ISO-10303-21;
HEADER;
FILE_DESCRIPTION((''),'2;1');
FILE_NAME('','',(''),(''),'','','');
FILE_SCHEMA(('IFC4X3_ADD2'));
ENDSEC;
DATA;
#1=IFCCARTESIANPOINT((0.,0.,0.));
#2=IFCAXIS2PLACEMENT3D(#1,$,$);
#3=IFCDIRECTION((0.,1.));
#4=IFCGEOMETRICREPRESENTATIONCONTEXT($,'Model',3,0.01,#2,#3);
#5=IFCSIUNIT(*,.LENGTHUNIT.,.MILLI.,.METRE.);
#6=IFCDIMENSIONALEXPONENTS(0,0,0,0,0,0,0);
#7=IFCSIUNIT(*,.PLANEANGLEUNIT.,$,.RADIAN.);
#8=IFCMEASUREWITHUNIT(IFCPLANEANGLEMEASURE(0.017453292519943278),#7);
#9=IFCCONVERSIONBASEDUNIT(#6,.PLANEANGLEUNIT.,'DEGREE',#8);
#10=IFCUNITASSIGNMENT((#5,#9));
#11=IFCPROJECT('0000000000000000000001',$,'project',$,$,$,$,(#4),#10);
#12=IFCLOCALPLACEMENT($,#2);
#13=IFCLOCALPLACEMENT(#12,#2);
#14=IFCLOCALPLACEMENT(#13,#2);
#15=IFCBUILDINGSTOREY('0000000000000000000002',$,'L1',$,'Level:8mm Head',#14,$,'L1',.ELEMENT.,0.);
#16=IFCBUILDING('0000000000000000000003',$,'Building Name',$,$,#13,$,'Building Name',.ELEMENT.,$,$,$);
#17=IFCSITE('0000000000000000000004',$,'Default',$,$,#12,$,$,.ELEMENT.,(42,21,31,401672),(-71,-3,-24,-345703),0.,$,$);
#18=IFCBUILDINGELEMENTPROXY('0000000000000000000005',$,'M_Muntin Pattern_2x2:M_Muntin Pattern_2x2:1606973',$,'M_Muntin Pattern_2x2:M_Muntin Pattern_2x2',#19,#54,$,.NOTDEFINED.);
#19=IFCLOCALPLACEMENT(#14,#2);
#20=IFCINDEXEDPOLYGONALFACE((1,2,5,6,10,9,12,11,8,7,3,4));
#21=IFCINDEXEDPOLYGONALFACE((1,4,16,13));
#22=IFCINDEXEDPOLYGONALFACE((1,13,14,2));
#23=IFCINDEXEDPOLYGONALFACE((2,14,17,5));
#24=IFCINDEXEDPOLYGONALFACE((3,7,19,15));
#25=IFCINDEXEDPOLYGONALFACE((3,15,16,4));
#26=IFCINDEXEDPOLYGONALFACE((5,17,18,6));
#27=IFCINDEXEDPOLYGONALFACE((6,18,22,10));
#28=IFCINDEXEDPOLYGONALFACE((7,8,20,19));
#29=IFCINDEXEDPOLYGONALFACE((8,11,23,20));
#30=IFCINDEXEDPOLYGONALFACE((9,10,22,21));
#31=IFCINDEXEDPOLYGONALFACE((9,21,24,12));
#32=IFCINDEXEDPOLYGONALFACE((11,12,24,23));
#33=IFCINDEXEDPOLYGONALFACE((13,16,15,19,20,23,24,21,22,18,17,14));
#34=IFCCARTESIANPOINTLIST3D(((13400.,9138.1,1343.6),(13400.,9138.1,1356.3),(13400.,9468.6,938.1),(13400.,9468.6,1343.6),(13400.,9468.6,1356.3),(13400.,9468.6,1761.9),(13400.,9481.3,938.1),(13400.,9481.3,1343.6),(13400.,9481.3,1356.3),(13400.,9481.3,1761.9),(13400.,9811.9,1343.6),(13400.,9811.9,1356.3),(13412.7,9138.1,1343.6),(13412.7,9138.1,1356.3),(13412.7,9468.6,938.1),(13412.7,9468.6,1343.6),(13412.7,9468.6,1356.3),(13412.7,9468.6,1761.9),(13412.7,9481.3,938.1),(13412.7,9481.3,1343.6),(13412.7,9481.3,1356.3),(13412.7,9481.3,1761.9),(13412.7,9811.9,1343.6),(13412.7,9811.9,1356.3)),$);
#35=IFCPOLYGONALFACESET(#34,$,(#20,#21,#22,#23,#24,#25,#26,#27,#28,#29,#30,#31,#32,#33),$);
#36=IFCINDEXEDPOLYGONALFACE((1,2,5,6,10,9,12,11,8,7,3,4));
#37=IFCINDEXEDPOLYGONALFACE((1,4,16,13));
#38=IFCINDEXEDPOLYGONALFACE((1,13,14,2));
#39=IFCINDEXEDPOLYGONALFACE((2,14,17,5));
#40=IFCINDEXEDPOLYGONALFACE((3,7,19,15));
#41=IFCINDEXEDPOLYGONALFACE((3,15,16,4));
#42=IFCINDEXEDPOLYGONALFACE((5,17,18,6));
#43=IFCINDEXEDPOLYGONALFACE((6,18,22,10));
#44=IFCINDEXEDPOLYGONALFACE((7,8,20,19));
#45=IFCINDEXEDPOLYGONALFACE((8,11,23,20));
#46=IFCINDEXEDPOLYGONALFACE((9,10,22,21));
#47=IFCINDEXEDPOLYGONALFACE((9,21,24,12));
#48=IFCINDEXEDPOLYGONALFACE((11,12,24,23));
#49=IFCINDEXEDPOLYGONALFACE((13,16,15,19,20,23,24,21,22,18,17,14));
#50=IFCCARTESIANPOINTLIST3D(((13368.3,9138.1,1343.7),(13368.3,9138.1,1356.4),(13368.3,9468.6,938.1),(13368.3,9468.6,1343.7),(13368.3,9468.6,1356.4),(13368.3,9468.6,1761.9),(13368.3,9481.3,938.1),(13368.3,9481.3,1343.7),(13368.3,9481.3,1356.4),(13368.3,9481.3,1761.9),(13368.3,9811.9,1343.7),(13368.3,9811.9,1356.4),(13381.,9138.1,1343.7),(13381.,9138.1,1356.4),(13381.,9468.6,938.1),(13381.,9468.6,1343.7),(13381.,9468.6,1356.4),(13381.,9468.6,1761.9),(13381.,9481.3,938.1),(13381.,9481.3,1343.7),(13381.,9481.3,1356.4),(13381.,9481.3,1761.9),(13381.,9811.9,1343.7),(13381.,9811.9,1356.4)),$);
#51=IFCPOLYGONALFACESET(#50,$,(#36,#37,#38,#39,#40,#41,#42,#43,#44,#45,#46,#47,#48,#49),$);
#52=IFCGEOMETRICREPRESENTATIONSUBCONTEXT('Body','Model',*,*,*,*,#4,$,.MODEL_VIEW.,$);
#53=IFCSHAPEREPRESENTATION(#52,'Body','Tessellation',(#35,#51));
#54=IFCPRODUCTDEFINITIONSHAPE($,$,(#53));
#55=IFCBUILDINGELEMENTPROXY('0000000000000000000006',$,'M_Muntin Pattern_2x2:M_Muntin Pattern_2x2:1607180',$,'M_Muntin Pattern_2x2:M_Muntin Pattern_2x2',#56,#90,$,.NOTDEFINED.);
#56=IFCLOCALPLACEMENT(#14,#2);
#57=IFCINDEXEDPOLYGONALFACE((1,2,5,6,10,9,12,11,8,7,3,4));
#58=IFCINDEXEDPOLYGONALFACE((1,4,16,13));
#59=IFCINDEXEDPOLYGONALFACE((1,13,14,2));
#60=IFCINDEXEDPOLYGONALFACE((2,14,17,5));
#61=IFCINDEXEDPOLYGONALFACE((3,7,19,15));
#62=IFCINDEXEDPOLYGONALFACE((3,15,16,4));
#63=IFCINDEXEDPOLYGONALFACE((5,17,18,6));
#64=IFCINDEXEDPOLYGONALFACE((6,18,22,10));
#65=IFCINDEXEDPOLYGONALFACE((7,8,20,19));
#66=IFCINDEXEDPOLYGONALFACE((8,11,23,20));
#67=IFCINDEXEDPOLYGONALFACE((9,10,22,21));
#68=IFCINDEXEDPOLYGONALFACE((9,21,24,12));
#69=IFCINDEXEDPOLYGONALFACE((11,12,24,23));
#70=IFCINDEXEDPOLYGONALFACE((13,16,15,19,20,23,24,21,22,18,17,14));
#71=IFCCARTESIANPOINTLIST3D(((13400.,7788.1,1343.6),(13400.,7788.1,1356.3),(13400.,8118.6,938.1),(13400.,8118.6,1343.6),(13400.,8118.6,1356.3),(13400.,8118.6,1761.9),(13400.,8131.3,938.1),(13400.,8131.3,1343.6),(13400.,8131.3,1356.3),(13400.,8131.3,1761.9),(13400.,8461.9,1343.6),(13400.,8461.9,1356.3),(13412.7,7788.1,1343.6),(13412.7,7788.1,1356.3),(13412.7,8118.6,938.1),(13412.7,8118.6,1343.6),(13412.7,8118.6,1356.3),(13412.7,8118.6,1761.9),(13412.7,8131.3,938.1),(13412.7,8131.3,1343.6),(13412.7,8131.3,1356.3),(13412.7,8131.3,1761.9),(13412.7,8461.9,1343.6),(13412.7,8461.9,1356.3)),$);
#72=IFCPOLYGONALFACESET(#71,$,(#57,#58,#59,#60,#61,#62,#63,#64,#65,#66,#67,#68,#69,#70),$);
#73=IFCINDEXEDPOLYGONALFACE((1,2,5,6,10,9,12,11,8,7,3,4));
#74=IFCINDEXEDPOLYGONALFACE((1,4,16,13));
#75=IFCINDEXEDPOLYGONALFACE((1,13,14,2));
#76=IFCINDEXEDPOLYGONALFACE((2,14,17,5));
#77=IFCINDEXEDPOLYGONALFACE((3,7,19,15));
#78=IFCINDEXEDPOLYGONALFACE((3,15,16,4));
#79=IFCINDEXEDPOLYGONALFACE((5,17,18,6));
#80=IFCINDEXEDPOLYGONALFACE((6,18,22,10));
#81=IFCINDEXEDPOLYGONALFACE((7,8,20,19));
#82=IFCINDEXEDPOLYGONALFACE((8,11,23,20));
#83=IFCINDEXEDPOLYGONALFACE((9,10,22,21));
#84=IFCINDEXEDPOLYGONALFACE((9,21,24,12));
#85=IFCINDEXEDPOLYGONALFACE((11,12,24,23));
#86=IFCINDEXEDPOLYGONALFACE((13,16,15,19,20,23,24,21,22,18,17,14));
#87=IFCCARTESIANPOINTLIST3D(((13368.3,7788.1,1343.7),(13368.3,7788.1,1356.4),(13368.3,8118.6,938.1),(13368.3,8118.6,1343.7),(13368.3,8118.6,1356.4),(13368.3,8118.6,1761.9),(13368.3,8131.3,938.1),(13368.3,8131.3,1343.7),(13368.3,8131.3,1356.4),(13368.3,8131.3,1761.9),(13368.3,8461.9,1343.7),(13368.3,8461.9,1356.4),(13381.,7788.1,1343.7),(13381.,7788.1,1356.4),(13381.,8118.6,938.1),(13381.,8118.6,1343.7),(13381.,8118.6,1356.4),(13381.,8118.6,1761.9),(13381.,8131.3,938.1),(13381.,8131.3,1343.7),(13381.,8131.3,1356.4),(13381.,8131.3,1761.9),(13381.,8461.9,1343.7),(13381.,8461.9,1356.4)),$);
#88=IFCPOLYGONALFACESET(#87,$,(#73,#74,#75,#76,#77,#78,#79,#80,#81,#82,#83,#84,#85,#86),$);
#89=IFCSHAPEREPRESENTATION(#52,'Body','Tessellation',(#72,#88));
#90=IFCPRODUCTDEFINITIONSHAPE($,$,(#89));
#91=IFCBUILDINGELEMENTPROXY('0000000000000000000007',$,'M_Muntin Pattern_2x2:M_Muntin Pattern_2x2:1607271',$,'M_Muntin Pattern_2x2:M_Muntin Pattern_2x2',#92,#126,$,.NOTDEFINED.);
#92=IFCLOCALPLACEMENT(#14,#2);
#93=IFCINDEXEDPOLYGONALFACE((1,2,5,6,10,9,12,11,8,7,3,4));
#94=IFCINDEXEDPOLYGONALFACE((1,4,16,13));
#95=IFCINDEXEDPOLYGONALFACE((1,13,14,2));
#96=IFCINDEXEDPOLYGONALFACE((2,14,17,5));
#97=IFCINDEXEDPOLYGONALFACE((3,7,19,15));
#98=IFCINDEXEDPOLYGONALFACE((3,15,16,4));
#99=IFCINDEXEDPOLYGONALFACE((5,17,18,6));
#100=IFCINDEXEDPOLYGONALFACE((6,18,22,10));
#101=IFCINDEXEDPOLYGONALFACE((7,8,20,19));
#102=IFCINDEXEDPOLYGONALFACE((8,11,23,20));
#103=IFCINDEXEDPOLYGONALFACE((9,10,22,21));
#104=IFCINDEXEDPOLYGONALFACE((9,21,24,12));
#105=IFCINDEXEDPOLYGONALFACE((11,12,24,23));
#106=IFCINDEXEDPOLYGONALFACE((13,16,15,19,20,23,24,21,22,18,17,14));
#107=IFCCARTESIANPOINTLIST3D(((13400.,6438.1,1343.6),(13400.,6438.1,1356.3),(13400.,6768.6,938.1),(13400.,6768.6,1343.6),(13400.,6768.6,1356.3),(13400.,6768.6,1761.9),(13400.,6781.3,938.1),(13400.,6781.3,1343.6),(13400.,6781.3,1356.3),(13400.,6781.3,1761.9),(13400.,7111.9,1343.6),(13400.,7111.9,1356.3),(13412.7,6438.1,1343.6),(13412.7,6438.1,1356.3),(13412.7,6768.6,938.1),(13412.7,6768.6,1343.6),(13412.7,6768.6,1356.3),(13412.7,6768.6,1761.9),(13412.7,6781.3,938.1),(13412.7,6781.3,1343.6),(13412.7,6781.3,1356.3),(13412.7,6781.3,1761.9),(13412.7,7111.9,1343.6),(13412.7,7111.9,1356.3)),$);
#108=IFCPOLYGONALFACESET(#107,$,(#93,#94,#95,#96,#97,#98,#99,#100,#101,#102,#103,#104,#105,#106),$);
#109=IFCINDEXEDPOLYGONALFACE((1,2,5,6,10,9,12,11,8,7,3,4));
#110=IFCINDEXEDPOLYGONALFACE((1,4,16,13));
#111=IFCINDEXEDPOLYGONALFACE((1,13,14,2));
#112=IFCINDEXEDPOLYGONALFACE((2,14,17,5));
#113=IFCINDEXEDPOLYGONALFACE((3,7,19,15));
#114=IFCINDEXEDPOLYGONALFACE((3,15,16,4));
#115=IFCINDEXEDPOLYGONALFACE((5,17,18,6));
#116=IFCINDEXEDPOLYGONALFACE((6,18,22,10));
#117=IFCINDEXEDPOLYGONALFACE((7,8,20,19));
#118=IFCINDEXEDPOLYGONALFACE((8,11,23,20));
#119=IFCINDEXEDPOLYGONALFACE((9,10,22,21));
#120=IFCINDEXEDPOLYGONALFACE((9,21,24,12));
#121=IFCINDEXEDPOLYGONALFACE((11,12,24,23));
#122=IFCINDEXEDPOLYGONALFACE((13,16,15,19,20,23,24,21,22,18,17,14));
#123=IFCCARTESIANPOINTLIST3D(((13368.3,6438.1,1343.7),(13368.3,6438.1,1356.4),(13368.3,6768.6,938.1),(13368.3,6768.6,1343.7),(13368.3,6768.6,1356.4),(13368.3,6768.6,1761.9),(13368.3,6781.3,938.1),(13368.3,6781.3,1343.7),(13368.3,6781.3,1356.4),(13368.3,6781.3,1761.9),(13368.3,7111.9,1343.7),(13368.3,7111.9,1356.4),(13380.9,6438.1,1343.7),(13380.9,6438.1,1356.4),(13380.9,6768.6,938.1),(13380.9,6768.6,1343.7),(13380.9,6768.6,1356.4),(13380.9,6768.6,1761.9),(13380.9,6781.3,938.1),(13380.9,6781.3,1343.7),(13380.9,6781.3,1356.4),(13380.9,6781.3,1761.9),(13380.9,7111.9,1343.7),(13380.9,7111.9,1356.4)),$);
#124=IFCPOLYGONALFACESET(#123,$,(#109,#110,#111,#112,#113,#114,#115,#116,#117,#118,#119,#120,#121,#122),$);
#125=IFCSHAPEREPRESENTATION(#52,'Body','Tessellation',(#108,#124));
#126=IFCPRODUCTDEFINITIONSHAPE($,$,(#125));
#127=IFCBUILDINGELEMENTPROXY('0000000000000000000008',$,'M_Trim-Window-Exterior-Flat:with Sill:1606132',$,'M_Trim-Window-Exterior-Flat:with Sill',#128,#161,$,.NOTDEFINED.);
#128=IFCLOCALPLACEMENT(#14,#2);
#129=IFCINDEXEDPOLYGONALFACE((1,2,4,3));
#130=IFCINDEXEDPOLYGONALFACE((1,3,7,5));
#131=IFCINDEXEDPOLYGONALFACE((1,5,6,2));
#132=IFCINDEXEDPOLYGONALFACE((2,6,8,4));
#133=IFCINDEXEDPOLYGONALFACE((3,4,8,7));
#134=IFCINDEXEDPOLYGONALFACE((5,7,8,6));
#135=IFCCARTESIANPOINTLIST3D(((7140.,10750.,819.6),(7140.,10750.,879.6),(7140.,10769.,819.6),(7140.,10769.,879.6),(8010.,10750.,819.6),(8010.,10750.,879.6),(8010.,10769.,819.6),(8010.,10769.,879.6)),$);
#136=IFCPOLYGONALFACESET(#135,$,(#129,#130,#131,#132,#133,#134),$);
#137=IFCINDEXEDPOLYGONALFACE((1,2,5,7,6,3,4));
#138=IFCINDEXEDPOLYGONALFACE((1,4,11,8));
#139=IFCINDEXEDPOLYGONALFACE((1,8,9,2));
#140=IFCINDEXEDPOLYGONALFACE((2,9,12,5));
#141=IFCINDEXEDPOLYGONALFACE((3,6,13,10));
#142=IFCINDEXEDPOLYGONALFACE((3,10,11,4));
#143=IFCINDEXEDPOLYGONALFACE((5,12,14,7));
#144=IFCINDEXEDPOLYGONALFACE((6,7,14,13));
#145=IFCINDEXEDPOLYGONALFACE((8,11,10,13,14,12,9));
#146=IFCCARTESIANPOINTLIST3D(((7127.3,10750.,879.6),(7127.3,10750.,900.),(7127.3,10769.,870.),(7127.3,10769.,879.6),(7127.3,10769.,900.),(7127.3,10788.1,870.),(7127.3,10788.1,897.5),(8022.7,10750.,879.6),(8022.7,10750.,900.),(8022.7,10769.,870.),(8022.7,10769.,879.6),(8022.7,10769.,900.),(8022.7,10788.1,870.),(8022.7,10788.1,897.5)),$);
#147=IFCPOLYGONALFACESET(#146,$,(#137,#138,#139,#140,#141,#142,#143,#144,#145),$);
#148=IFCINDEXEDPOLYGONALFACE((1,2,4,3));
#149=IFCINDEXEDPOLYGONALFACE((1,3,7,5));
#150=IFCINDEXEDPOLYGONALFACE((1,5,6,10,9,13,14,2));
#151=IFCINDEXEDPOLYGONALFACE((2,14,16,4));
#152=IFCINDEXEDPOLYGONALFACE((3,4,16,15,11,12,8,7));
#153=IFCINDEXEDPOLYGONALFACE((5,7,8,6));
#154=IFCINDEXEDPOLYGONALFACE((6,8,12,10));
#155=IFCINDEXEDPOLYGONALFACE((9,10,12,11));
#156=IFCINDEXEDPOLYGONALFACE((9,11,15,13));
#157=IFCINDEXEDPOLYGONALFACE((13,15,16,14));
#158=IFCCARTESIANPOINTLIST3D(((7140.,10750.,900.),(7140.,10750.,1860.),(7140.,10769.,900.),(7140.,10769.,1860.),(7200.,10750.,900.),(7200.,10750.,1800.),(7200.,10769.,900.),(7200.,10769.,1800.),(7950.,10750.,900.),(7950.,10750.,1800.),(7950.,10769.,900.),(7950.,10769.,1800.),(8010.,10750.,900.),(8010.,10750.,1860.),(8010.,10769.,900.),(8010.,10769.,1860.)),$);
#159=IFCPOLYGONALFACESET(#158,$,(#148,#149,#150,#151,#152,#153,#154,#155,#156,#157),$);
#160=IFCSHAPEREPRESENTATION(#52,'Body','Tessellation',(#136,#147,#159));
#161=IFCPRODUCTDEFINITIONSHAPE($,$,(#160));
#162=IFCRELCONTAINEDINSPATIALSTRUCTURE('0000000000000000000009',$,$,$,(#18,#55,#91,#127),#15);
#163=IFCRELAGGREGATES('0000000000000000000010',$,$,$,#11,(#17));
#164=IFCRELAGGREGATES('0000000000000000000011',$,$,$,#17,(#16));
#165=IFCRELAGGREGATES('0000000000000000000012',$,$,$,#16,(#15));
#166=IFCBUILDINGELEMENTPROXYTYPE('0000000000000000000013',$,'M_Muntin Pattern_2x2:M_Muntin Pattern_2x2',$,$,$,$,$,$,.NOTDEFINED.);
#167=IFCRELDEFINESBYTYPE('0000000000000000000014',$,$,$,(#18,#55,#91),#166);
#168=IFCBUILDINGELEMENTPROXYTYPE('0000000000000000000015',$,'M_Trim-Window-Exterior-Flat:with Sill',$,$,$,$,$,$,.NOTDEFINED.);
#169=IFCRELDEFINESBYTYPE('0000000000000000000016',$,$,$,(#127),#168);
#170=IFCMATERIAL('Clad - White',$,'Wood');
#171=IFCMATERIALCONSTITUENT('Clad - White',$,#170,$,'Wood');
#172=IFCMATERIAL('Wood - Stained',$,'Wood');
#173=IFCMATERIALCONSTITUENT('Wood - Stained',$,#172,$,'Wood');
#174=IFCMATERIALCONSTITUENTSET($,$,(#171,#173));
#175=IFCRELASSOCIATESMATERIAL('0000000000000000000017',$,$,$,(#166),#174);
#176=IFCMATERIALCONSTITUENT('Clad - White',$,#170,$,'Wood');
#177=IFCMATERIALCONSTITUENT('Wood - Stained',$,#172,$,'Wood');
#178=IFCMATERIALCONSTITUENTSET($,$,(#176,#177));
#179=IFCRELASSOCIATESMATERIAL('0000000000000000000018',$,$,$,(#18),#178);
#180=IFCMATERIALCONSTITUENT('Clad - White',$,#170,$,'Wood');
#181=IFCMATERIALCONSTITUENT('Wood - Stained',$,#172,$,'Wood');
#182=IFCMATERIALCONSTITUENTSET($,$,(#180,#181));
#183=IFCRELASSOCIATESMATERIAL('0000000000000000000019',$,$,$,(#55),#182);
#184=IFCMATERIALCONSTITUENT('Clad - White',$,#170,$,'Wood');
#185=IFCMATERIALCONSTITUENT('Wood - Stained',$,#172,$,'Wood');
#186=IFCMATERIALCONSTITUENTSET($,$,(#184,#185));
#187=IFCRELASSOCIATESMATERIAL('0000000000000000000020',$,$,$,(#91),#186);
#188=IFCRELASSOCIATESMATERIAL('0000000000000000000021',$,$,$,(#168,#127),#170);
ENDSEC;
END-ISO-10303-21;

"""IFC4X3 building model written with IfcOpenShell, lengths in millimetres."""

from ifc_helpers import new_model, entity, si_unit, converted_unit, direction, frame, frame_2d, origin, place, context, subcontext, project, spatial, polyline, rectangle, outline, extrude, source, transform, mapped, material, constituent, constituent_set, type_object, type_shapes, element, save


model = new_model("IFC4X3")

# Units and contexts
model_context = context("Model", 3, precision=0.01, world=origin(), true_north=direction((0.0, 1.0)))
body_context = subcontext(model_context, "Body", "Model", "MODEL_VIEW")
ifc_project = project(units=[si_unit("LENGTHUNIT", "METRE", prefix="MILLI"), converted_unit("PLANEANGLEUNIT", "DEGREE", entity("IfcPlaneAngleMeasure", 0.017453292519943278), si_unit("PLANEANGLEUNIT", "RADIAN"), dimensions=[0, 0, 0, 0, 0, 0, 0])], contexts=[model_context])

# Site, building, storey
site_placement = place(None, origin())
site = spatial("IfcSite", under=ifc_project, at=site_placement, Name="Default", CompositionType="ELEMENT", RefLatitude=(42, 21, 31, 401672), RefLongitude=(-71, -3, -24, -345703), RefElevation=0.0)
building_placement = place(site_placement, origin())
building = spatial("IfcBuilding", under=site, at=building_placement, Name="Building Name", LongName="Building Name", CompositionType="ELEMENT")
storey_placement = place(building_placement, origin())
storey = spatial("IfcBuildingStorey", under=building, at=storey_placement, Name="L1", ObjectType="Level:8mm Head", LongName="L1", CompositionType="ELEMENT", Elevation=0.0)

# Building element proxies
ifc_material_1 = material(Name="Clad - White", Category="Wood")
ifc_material_2 = material(Name="Wood - Stained", Category="Wood")
ifc_constituent_1 = constituent(ifc_material_1, Name="Clad - White", Category="Wood")
ifc_constituent_2 = constituent(ifc_material_2, Name="Wood - Stained", Category="Wood")
ifc_constituent_set_1 = constituent_set(constituents=[ifc_constituent_1, ifc_constituent_2])
building_element_proxy_type_1 = type_object("IfcBuildingElementProxyType", Name="M_Muntin Pattern_2x2:M_Muntin Pattern_2x2", PredefinedType="NOTDEFINED", material=ifc_constituent_set_1)
shared_shape_1 = source(origin(), body_context, "Body", "SweptSolid", [
    extrude(outline(polyline([(6.4, -6.4), (411.9, -6.4), (411.9, 6.3), (6.4, 6.3), (6.4, 336.9), (-6.3, 336.9), (-6.3, 6.3), (-411.9, 6.3), (-411.9, -6.4), (-6.3, -6.4), (-6.3, -336.9), (6.4, -336.9), (6.4, -6.4)])), frame((0.0, -22.2, 411.9), z_axis=(0.0, 1.0, 0.0), x_axis=(0.0, 0.0, 1.0)), (0.0, 0.0, 1.0), 12.7),
    extrude(outline(polyline([(6.4, -6.4), (411.9, -6.4), (411.9, 6.3), (6.4, 6.3), (6.4, 336.9), (-6.3, 336.9), (-6.3, 6.3), (-411.9, 6.3), (-411.9, -6.4), (-6.3, -6.4), (-6.3, -336.9), (6.4, -336.9), (6.4, -6.4)])), frame((0.0, 9.5, 411.9), z_axis=(0.0, 1.0, 0.0), x_axis=(0.0, 0.0, 1.0)), (0.0, 0.0, 1.0), 12.7),
])
type_shapes(building_element_proxy_type_1, [shared_shape_1])
ifc_constituent_3 = constituent(ifc_material_1, Name="Clad - White", Category="Wood")
ifc_constituent_4 = constituent(ifc_material_2, Name="Wood - Stained", Category="Wood")
ifc_constituent_set_2 = constituent_set(constituents=[ifc_constituent_3, ifc_constituent_4])
proxy_1_placement = place(storey_placement, frame((13390.5, 9475.0, 938.1), z_axis=(0.0, 0.0, 1.0), x_axis=(0.0, 1.0, 0.0)))
element("IfcBuildingElementProxy", 1, at=proxy_1_placement, inside=storey, type_object=building_element_proxy_type_1, material=ifc_constituent_set_2, Name="M_Muntin Pattern_2x2:M_Muntin Pattern_2x2:1606973", ObjectType="M_Muntin Pattern_2x2:M_Muntin Pattern_2x2", PredefinedType="NOTDEFINED", context=body_context, shape_type="MappedRepresentation", body=[
    mapped(shared_shape_1, transform((0.0, 0.0, 0.0), scale=1.0)),
])
ifc_constituent_5 = constituent(ifc_material_1, Name="Clad - White", Category="Wood")
ifc_constituent_6 = constituent(ifc_material_2, Name="Wood - Stained", Category="Wood")
ifc_constituent_set_3 = constituent_set(constituents=[ifc_constituent_5, ifc_constituent_6])
proxy_2_placement = place(storey_placement, frame((13390.5, 8125.0, 938.1), z_axis=(0.0, 0.0, 1.0), x_axis=(0.0, 1.0, 0.0)))
element("IfcBuildingElementProxy", 2, at=proxy_2_placement, inside=storey, type_object=building_element_proxy_type_1, material=ifc_constituent_set_3, Name="M_Muntin Pattern_2x2:M_Muntin Pattern_2x2:1607180", ObjectType="M_Muntin Pattern_2x2:M_Muntin Pattern_2x2", PredefinedType="NOTDEFINED", context=body_context, shape_type="MappedRepresentation", body=[
    mapped(shared_shape_1, transform((0.0, 0.0, 0.0), scale=1.0)),
])
ifc_constituent_7 = constituent(ifc_material_1, Name="Clad - White", Category="Wood")
ifc_constituent_8 = constituent(ifc_material_2, Name="Wood - Stained", Category="Wood")
ifc_constituent_set_4 = constituent_set(constituents=[ifc_constituent_7, ifc_constituent_8])
proxy_3_placement = place(storey_placement, frame((13390.5, 6775.0, 938.1), z_axis=(0.0, 0.0, 1.0), x_axis=(0.0, 1.0, 0.0)))
element("IfcBuildingElementProxy", 3, at=proxy_3_placement, inside=storey, type_object=building_element_proxy_type_1, material=ifc_constituent_set_4, Name="M_Muntin Pattern_2x2:M_Muntin Pattern_2x2:1607271", ObjectType="M_Muntin Pattern_2x2:M_Muntin Pattern_2x2", PredefinedType="NOTDEFINED", context=body_context, shape_type="MappedRepresentation", body=[
    mapped(shared_shape_1, transform((0.0, 0.0, 0.0), scale=1.0)),
])
building_element_proxy_type_2 = type_object("IfcBuildingElementProxyType", Name="M_Trim-Window-Exterior-Flat:with Sill", PredefinedType="NOTDEFINED", material=ifc_material_1)
shared_shape_2 = source(origin(), body_context, "Body", "SweptSolid", [
    extrude(rectangle(XDim=870.0, YDim=60.0, at=frame_2d((0.0, 0.0), x_axis=(1.0, 0.0))), frame((0.0, -950.4, 0.0), z_axis=(0.0, 0.0, 1.0), x_axis=(-1.0, 0.0, 0.0)), (0.0, 0.0, 1.0), 19.0),
    extrude(outline(polyline([(-19.0, -15.2), (0.0, -15.2), (0.0, -5.7), (19.0, -5.7), (19.0, 14.8), (0.0, 14.8), (-19.0, 12.3), (-19.0, -15.2)])), frame((-447.7, -914.8, 19.0), z_axis=(1.0, 0.0, 0.0), x_axis=(0.0, 0.0, -1.0)), (0.0, 0.0, 1.0), 895.4),
    extrude(outline(polyline([(-495.0, -435.0), (465.0, -435.0), (465.0, -375.0), (-435.0, -375.0), (-435.0, 375.0), (465.0, 375.0), (465.0, 435.0), (-495.0, 435.0), (-495.0, -435.0)])), frame((0.0, -435.0, 0.0), z_axis=(0.0, 0.0, 1.0), x_axis=(0.0, -1.0, 0.0)), (0.0, 0.0, 1.0), 19.0),
])
type_shapes(building_element_proxy_type_2, [shared_shape_2])
for number, where, z_axis, x_axis, name in (
    (4, (7575.0, 10750.0, 1800.0), (0.0, 1.0, 0.0), (-1.0, 0.0, 0.0), "M_Trim-Window-Exterior-Flat:with Sill:1606132"),
):
    element("IfcBuildingElementProxy", number, at=place(storey_placement, frame(where, z_axis=z_axis, x_axis=x_axis)), inside=storey, type_object=building_element_proxy_type_2, material=ifc_material_1, Name=name, ObjectType="M_Trim-Window-Exterior-Flat:with Sill", PredefinedType="NOTDEFINED", context=body_context, shape_type="MappedRepresentation", body=[
        mapped(shared_shape_2, transform((0.0, 0.0, 0.0), scale=1.0)),
    ])

save(model, "model.ifc")
